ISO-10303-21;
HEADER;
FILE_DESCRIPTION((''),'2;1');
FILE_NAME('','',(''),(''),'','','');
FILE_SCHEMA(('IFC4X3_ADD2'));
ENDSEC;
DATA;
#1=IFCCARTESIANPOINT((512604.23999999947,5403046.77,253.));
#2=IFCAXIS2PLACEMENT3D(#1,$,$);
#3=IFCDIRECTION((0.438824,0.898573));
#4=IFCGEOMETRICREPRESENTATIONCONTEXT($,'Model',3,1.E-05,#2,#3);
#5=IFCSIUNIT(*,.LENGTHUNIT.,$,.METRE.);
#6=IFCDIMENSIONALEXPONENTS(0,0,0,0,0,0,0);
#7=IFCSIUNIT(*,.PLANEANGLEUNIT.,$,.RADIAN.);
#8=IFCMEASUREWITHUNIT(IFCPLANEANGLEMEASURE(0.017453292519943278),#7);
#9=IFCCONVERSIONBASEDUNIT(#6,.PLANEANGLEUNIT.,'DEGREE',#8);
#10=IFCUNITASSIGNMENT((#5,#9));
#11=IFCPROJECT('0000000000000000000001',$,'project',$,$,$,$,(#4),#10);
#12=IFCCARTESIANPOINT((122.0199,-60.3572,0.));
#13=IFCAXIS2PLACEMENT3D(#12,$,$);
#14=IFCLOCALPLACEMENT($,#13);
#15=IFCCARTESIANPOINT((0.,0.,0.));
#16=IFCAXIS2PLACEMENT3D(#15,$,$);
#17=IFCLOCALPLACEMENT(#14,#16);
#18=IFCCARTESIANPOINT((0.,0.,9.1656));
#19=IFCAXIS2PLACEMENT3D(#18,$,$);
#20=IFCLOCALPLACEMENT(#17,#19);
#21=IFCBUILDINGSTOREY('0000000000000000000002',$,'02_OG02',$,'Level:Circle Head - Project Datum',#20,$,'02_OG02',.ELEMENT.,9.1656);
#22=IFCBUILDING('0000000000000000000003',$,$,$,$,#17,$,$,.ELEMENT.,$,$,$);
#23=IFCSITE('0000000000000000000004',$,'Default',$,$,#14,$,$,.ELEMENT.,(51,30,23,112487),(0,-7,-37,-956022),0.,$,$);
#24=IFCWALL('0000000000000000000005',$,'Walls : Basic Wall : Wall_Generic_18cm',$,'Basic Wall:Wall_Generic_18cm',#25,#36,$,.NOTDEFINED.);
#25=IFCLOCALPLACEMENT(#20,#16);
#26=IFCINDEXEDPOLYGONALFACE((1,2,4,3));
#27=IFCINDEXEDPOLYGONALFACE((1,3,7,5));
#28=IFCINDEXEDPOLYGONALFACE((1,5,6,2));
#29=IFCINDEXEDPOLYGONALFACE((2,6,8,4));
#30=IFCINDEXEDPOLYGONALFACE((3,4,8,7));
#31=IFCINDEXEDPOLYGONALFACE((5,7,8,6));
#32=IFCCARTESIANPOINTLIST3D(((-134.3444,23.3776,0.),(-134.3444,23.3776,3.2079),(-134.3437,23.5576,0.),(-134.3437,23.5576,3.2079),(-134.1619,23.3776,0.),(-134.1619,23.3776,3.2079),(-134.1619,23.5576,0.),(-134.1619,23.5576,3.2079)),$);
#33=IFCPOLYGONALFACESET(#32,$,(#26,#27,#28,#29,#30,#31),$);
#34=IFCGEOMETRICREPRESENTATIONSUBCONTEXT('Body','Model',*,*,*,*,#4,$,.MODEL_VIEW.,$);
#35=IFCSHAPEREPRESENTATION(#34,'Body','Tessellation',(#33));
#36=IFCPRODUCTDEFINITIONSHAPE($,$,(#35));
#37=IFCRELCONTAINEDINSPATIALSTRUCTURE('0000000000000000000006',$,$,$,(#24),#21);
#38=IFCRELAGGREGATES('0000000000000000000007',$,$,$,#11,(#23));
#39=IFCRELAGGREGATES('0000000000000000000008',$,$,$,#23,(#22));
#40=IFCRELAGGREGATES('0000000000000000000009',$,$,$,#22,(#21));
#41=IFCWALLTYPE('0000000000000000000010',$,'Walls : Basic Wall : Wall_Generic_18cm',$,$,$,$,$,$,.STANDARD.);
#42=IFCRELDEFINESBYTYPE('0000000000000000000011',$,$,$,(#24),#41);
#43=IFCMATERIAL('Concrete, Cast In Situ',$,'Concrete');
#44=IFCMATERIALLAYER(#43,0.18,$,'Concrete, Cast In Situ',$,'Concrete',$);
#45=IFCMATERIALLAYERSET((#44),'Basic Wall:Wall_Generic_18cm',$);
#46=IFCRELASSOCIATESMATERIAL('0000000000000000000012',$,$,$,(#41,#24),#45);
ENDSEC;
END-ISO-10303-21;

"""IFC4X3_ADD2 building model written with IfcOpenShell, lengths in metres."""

from ifc_helpers import new_model, entity, si_unit, converted_unit, direction, frame, origin, place, context, subcontext, project, spatial, polyline, outline, extrude, clip, bounded_halfspace, material, layer, layer_set, type_object, element, save


model = new_model("IFC4X3_ADD2")

# Units and contexts
model_context = context("Model", 3, precision=1e-05, world=frame((512604.23999999947, 5403046.77, 253.0)), true_north=direction((0.438824, 0.898573)))
body_context = subcontext(model_context, "Body", "Model", "MODEL_VIEW")
ifc_project = project(units=[si_unit("LENGTHUNIT", "METRE"), converted_unit("PLANEANGLEUNIT", "DEGREE", entity("IfcPlaneAngleMeasure", 0.017453292519943278), si_unit("PLANEANGLEUNIT", "RADIAN"), dimensions=[0, 0, 0, 0, 0, 0, 0])], contexts=[model_context])

# Site, building, storey
site_placement = place(None, frame((122.0199, -60.3572, 0.0)))
site = spatial("IfcSite", under=ifc_project, at=site_placement, Name="Default", CompositionType="ELEMENT", RefLatitude=(51, 30, 23, 112487), RefLongitude=(0, -7, -37, -956022), RefElevation=0.0)
building_placement = place(site_placement, origin())
building = spatial("IfcBuilding", under=site, at=building_placement, CompositionType="ELEMENT")
storey_placement = place(building_placement, frame((0.0, 0.0, 9.1656)))
storey = spatial("IfcBuildingStorey", under=building, at=storey_placement, Name="02_OG02", ObjectType="Level:Circle Head - Project Datum", LongName="02_OG02", CompositionType="ELEMENT", Elevation=9.1656)

# Shared definitions
ifc_material_1 = material(Name="Concrete, Cast In Situ", Category="Concrete")

# Wall
ifc_layer_1 = layer(ifc_material_1, 0.18, Name="Concrete, Cast In Situ", Category="Concrete")
ifc_layer_set_1 = layer_set([ifc_layer_1], Name="Basic Wall:Wall_Generic_18cm")
wall_type_1 = type_object("IfcWallType", Name="Walls : Basic Wall : Wall_Generic_18cm", PredefinedType="STANDARD", material=ifc_layer_set_1)
wall_1_placement = place(storey_placement, frame((-134.3444, 23.4676, 0.0)))
element("IfcWall", 1, at=wall_1_placement, inside=storey, type_object=wall_type_1, material=ifc_layer_set_1, Name="Walls : Basic Wall : Wall_Generic_18cm", ObjectType="Basic Wall:Wall_Generic_18cm", PredefinedType="NOTDEFINED", context=body_context, shape_type="Clipping", body=[
    clip(extrude(outline(polyline([(0.1826, -0.09), (0.1826, 0.09), (0.0008, 0.09), (0.0, -0.09), (0.1826, -0.09)])), origin(), (0.0, 0.0, 1.0), 3.2079), bounded_halfspace(frame((0.0, -0.09, 3.2079), z_axis=(0.0, 0.0, -1.0), x_axis=(-0.000002, -1.0, 0.0)), True, frame((0.0, -0.09, 3.2079)), polyline([(0.0, 0.0), (0.1826, 0.0), (0.1826, 0.18), (0.0008, 0.18), (0.0, 0.0)]))),
])

save(model, "model.ifc")
